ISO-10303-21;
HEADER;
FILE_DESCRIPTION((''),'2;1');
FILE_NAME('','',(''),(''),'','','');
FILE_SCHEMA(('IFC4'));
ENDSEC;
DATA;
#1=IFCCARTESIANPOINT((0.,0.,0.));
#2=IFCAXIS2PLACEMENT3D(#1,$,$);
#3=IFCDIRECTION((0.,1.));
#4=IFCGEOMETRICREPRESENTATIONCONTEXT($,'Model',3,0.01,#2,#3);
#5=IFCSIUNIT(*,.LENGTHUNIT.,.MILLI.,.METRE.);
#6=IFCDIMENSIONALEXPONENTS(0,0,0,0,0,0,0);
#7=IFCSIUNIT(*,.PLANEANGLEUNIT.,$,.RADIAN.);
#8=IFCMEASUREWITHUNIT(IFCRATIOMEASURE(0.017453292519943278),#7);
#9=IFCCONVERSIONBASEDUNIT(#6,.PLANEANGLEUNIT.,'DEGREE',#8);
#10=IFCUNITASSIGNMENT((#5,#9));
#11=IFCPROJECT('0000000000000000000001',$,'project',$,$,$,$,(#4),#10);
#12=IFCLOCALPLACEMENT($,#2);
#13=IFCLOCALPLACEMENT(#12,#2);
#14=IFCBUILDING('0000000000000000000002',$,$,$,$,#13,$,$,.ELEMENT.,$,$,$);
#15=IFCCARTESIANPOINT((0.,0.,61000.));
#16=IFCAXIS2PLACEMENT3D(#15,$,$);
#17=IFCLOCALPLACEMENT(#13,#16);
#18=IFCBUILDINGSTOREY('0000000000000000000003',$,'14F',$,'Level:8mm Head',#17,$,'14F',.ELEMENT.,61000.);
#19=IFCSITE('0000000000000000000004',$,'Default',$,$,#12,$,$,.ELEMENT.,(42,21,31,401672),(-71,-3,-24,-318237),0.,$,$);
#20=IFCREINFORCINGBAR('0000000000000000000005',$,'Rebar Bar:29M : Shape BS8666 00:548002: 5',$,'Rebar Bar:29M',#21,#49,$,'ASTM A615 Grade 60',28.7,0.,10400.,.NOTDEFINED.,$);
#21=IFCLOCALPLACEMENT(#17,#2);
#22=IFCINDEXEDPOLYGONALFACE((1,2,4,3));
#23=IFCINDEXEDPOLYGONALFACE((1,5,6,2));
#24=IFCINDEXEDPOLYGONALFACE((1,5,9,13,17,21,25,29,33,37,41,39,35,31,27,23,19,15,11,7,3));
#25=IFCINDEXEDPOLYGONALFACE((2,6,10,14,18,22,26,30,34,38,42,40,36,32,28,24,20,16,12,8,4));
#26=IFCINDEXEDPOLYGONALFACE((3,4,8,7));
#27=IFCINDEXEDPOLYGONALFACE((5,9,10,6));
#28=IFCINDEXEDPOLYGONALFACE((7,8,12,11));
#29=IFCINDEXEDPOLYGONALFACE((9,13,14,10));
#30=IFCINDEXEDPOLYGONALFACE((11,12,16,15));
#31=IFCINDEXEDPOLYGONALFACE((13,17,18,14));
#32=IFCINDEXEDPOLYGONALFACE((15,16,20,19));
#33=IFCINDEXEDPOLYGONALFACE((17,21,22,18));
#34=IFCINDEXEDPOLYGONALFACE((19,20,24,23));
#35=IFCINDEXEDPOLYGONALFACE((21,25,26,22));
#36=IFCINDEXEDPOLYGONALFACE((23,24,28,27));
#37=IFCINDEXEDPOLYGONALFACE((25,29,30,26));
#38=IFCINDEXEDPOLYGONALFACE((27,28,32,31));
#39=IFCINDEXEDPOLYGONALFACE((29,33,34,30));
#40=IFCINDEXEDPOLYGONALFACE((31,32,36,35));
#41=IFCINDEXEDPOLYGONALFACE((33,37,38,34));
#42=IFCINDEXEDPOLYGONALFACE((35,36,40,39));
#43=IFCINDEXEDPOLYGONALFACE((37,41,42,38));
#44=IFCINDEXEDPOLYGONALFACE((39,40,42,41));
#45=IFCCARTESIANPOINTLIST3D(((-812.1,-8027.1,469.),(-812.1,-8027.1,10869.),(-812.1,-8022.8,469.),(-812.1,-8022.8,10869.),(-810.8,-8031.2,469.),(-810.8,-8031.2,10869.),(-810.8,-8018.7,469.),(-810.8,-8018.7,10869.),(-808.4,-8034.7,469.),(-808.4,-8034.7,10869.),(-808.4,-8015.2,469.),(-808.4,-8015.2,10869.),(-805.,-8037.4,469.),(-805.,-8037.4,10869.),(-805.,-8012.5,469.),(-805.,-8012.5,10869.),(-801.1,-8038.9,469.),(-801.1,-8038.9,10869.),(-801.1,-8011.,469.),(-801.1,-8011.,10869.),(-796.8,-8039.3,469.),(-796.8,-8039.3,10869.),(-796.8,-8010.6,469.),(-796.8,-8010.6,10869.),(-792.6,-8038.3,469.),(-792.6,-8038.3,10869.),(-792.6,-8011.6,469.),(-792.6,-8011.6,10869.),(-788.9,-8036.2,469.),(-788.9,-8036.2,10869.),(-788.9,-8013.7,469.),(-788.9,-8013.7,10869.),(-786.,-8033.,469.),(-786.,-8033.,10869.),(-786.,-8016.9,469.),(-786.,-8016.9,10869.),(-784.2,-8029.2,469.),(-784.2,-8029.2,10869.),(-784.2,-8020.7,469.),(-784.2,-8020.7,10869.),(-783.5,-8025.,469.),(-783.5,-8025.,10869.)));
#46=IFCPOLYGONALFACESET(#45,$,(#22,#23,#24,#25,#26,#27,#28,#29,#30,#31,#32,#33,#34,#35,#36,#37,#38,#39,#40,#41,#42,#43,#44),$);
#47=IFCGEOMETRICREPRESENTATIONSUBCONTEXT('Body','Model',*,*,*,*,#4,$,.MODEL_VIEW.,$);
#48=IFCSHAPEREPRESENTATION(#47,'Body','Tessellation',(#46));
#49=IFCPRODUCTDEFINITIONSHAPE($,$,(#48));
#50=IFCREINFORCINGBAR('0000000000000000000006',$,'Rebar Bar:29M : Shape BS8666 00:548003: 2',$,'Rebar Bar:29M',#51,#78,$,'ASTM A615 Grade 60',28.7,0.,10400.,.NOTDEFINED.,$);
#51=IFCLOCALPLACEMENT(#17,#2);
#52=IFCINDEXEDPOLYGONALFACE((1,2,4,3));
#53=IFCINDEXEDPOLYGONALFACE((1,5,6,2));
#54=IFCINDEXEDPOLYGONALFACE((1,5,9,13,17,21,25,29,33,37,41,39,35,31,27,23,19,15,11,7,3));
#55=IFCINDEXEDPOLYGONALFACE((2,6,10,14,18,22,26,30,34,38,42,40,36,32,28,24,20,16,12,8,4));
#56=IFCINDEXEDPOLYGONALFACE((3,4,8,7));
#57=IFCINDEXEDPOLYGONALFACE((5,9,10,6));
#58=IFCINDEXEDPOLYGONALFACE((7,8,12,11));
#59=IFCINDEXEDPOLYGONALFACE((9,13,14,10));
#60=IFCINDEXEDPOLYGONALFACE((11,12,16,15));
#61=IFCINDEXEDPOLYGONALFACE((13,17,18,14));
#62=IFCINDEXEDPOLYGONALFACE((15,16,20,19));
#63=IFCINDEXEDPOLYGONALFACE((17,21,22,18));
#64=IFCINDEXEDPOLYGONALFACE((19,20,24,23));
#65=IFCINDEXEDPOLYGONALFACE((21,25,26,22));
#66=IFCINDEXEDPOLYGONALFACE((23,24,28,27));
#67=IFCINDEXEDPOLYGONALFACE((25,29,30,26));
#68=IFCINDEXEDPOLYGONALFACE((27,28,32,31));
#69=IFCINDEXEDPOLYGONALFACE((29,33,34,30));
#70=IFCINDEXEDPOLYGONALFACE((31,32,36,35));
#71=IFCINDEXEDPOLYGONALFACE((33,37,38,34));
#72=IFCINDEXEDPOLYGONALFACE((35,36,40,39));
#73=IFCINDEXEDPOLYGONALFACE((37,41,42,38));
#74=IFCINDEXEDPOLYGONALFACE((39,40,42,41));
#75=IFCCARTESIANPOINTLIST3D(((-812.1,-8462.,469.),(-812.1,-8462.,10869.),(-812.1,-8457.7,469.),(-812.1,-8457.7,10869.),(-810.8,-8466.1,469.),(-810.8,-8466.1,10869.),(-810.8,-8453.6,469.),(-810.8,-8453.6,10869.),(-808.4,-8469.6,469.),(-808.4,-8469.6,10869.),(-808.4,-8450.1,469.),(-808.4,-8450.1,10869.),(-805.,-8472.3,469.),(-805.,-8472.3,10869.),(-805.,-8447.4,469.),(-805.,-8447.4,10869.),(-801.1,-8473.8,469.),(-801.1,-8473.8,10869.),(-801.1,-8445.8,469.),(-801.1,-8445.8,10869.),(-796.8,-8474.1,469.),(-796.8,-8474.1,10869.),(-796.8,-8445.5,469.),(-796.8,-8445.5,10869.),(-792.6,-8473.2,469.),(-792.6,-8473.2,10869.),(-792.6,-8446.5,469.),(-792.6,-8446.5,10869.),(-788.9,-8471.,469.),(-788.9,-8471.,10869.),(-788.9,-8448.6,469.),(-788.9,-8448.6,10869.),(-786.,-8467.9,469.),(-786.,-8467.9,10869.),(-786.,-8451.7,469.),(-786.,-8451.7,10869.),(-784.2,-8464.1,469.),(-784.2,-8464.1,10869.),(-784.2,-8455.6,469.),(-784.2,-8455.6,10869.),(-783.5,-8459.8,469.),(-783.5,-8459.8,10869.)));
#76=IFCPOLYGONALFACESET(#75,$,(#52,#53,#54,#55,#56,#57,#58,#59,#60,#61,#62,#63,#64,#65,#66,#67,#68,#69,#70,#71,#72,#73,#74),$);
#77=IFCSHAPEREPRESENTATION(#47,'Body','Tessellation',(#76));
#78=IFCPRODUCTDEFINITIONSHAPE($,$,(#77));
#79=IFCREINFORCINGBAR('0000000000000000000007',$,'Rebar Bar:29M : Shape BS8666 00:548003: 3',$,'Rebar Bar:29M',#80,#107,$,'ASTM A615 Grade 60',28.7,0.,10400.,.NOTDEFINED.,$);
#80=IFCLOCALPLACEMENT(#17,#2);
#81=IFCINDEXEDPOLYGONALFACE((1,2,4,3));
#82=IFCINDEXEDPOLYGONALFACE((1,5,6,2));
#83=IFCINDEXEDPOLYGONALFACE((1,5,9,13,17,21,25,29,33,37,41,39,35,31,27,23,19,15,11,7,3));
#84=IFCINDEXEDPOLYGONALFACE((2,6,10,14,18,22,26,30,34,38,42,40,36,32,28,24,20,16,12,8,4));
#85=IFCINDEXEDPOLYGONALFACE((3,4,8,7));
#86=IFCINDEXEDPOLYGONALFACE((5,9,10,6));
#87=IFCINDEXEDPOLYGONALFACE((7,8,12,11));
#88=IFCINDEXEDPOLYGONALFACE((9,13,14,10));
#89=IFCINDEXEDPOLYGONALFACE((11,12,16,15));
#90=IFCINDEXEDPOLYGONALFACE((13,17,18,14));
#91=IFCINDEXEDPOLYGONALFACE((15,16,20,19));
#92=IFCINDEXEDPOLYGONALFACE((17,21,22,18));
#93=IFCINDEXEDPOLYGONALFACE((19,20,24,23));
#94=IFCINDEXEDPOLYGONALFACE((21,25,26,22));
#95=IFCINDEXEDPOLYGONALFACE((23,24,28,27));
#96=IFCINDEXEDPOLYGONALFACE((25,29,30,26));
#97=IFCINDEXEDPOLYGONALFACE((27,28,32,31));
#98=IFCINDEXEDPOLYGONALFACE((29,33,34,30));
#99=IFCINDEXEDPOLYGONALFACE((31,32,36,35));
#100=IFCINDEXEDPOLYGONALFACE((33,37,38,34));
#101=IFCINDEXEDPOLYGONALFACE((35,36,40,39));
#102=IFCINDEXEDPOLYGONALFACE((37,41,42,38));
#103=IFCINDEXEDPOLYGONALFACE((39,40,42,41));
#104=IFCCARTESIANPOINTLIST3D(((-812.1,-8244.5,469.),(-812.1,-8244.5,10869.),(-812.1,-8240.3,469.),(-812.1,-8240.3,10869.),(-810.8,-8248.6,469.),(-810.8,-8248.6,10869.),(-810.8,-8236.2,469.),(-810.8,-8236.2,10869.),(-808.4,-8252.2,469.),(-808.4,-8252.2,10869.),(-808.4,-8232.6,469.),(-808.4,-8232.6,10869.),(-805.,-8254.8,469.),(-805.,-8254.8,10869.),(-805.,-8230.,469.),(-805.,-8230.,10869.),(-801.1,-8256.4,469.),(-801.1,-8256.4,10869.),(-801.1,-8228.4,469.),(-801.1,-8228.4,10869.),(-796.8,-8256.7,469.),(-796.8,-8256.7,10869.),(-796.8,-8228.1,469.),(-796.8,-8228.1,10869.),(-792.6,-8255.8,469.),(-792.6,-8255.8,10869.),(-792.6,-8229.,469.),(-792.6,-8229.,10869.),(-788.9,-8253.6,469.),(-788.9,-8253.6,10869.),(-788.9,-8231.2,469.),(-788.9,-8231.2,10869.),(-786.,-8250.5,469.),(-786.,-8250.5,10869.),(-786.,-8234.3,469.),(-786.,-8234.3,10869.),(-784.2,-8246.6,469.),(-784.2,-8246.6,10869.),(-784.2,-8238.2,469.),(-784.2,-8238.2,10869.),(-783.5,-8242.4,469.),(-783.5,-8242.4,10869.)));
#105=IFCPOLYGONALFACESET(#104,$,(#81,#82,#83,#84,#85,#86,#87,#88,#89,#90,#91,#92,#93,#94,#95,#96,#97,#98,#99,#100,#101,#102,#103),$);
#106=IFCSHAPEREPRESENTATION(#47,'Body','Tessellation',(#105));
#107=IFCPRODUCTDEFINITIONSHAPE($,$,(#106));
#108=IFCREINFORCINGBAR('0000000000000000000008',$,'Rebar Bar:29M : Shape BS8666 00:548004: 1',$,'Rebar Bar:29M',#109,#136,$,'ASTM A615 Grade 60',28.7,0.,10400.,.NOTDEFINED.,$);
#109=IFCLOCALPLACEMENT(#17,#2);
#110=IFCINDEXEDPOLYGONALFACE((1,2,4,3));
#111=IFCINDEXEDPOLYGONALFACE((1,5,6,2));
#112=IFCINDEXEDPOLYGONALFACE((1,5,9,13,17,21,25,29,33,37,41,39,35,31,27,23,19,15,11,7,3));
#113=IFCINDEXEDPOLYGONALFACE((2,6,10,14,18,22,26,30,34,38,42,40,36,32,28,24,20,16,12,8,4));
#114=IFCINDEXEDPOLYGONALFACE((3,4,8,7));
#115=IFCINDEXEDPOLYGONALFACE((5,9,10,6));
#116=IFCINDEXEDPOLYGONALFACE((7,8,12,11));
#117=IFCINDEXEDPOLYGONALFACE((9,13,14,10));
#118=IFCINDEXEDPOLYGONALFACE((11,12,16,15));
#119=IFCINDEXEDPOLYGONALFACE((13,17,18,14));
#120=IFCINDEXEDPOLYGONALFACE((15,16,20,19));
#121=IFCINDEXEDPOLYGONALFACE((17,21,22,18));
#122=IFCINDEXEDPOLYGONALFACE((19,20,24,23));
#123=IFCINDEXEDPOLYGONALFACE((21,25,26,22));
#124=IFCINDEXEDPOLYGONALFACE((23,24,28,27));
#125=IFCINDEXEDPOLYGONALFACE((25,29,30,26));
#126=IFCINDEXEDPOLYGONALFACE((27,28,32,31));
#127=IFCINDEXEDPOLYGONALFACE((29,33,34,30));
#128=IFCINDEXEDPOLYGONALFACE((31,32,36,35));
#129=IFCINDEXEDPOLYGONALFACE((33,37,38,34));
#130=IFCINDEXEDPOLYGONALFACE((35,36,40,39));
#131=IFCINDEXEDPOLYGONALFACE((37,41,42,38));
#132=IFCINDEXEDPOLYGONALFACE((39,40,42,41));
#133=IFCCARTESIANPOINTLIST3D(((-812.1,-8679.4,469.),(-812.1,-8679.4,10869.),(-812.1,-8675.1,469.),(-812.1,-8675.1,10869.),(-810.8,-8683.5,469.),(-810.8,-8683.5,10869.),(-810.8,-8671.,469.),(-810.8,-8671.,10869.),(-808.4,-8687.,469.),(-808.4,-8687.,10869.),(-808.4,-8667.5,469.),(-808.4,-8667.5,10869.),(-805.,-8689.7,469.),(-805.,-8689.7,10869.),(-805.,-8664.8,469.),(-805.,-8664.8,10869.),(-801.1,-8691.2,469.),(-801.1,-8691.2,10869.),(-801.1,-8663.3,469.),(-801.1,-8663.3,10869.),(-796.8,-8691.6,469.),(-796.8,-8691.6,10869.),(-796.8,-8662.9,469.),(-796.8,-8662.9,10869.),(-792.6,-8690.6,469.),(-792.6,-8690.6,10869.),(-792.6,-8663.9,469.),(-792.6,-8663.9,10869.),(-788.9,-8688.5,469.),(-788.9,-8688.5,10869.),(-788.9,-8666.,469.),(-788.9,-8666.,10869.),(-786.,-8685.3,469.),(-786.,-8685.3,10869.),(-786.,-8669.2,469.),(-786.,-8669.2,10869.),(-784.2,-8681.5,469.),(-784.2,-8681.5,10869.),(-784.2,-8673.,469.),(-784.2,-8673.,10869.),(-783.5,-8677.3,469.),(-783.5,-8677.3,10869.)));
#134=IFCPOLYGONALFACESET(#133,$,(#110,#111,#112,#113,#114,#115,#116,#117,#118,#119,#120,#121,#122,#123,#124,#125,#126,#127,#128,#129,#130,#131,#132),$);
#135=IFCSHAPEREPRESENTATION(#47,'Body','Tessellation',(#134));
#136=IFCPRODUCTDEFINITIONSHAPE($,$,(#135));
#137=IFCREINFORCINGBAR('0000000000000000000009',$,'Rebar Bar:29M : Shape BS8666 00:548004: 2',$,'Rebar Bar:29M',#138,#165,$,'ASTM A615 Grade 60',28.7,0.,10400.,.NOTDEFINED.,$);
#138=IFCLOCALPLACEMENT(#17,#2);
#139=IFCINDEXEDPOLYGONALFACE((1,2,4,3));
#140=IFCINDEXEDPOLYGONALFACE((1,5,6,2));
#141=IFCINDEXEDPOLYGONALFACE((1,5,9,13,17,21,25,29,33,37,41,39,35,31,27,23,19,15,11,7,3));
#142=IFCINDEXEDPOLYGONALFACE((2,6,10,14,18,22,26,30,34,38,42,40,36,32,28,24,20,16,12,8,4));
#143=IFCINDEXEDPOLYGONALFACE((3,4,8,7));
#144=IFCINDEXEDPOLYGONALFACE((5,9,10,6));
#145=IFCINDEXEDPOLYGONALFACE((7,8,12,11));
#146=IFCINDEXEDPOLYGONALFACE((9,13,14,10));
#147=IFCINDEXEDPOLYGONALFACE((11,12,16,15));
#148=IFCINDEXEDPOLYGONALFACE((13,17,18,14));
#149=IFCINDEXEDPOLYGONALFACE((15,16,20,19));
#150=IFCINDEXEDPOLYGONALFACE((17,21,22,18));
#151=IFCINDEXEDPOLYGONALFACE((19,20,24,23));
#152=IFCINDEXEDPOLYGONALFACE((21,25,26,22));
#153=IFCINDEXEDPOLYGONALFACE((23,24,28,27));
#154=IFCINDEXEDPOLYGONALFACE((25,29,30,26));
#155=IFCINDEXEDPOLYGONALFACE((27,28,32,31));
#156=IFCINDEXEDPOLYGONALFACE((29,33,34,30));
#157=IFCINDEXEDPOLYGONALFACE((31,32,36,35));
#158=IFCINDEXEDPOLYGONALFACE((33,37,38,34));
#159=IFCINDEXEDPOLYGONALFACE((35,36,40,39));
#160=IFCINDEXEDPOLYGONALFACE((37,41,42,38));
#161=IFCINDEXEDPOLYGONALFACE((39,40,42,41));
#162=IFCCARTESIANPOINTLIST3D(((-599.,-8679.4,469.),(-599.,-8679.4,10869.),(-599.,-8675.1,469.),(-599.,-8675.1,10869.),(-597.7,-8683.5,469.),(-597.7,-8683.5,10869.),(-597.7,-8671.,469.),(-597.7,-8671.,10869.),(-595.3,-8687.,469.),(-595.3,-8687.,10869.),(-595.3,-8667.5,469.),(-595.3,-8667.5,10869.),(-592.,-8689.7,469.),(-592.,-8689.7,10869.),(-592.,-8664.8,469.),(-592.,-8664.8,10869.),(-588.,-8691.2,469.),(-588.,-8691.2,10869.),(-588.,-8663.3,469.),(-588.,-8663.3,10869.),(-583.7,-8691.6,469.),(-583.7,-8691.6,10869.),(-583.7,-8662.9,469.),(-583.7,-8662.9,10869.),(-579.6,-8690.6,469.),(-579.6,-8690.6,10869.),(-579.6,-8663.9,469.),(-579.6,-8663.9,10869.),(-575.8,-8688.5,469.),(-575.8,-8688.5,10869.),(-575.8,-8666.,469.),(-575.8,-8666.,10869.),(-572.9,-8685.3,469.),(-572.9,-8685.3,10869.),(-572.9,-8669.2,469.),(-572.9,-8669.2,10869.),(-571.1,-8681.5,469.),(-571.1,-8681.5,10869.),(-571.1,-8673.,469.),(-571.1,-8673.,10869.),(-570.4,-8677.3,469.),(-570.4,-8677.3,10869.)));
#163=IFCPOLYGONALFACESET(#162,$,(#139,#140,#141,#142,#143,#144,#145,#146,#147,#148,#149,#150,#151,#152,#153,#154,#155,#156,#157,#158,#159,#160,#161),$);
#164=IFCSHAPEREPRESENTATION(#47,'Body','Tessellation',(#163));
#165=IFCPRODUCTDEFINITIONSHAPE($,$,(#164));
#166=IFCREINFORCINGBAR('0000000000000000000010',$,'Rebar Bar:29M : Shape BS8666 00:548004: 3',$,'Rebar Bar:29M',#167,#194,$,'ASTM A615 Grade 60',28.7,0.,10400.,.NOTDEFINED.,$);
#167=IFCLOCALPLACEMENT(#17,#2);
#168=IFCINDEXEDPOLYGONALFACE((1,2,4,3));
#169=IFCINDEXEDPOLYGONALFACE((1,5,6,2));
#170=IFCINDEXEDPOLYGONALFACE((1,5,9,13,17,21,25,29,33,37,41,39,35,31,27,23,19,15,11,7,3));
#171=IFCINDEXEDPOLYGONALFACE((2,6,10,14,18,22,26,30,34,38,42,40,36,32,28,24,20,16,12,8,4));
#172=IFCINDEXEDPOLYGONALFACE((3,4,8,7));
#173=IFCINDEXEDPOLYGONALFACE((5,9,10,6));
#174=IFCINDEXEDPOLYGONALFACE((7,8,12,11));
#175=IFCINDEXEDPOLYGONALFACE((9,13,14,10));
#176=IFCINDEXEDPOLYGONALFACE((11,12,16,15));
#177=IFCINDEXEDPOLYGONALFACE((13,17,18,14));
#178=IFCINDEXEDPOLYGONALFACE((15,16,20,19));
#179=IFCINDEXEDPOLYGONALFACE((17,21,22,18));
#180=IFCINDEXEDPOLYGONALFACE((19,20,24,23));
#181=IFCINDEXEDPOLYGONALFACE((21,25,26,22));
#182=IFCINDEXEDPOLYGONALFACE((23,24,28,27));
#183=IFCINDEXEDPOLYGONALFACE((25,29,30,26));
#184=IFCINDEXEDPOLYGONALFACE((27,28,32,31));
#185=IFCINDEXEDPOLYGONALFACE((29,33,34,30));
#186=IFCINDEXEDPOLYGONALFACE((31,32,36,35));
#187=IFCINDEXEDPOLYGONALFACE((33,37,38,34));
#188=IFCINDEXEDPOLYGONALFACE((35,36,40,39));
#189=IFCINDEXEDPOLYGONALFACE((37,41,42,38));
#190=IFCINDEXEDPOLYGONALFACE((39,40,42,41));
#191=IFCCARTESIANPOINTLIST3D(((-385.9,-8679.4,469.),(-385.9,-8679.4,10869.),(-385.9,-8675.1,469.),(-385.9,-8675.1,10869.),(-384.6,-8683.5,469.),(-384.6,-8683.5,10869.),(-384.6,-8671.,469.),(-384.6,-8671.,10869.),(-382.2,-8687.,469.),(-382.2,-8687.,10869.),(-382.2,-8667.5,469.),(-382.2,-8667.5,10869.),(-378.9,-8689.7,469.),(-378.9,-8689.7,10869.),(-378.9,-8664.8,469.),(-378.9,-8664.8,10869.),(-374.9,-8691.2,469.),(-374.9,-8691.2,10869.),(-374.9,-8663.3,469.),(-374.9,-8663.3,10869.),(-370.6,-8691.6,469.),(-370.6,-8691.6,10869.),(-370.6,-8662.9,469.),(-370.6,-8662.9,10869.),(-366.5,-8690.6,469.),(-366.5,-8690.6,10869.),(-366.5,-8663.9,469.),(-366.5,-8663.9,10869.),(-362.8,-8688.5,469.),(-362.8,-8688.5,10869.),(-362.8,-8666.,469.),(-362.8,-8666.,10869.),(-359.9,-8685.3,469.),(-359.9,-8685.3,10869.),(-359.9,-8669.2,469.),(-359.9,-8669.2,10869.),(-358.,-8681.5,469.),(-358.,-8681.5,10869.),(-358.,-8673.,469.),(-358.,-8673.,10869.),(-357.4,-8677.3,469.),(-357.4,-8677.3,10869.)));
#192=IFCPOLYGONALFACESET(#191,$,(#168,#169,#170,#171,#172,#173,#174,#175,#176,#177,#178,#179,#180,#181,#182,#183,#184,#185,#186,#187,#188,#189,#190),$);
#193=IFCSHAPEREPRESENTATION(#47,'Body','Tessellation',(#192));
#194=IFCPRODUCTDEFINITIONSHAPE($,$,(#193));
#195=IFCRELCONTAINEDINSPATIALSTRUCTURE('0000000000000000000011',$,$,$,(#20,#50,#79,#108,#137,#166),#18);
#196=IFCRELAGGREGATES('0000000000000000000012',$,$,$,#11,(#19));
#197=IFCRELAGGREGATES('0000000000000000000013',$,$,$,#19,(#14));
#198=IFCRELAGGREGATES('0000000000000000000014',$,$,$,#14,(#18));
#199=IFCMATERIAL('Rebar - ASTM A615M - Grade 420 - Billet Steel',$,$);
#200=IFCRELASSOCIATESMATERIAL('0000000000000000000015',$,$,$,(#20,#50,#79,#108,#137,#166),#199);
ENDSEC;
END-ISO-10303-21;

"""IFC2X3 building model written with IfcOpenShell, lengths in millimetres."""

from ifc_helpers import new_model, entity, si_unit, converted_unit, direction, frame, origin, place, context, subcontext, project, spatial, material, element, save


model = new_model("IFC2X3")

# Units and contexts
model_context = context("Model", 3, precision=0.01, world=origin(), true_north=direction((0.0, 1.0)))
body_context = subcontext(model_context, "Body", "Model", "MODEL_VIEW")
ifc_project = project(units=[si_unit("LENGTHUNIT", "METRE", prefix="MILLI"), converted_unit("PLANEANGLEUNIT", "DEGREE", entity("IfcRatioMeasure", 0.017453292519943278), si_unit("PLANEANGLEUNIT", "RADIAN"), dimensions=[0, 0, 0, 0, 0, 0, 0])], contexts=[model_context])

# Site, building, storey
site_placement = place(None, origin())
site = spatial("IfcSite", under=ifc_project, at=site_placement, Name="Default", CompositionType="ELEMENT", RefLatitude=(42, 21, 31, 401672), RefLongitude=(-71, -3, -24, -318237), RefElevation=0.0)
building_placement = place(site_placement, origin())
building = spatial("IfcBuilding", under=site, at=building_placement, CompositionType="ELEMENT")
storey_placement = place(building_placement, frame((0.0, 0.0, 61000.0)))
storey = spatial("IfcBuildingStorey", under=building, at=storey_placement, Name="14F", ObjectType="Level:8mm Head", LongName="14F", CompositionType="ELEMENT", Elevation=61000.0)

# Reinforcing bars
ifc_material_1 = material(Name="Rebar - ASTM A615M - Grade 420 - Billet Steel")
reinforcing_bar_1_placement = place(storey_placement, origin())
element("IfcReinforcingBar", 1, at=reinforcing_bar_1_placement, inside=storey, material=ifc_material_1, Name="Rebar Bar:29M : Shape BS8666 00:548002: 5", SteelGrade="ASTM A615 Grade 60", ObjectType="Rebar Bar:29M", BarLength=10400.0, BarRole="NOTDEFINED", CrossSectionArea=0.0, NominalDiameter=28.7, context=body_context, shape_type="AdvancedSweptSolid", body=[
    entity("IfcSweptDiskSolid", entity("IfcCompositeCurve", [entity("IfcCompositeCurveSegment", "CONTINUOUS", True, entity("IfcPolyline", [entity("IfcCartesianPoint", [-797.9, -8025.0, 469.0]), entity("IfcCartesianPoint", [-797.9, -8025.0, 10869.0])]))], False), 14.3, None, 0.0, 1.0),
])
reinforcing_bar_2_placement = place(storey_placement, origin())
element("IfcReinforcingBar", 2, at=reinforcing_bar_2_placement, inside=storey, material=ifc_material_1, Name="Rebar Bar:29M : Shape BS8666 00:548003: 2", SteelGrade="ASTM A615 Grade 60", ObjectType="Rebar Bar:29M", BarLength=10400.0, BarRole="NOTDEFINED", CrossSectionArea=0.0, NominalDiameter=28.7, context=body_context, shape_type="AdvancedSweptSolid", body=[
    entity("IfcSweptDiskSolid", entity("IfcCompositeCurve", [entity("IfcCompositeCurveSegment", "CONTINUOUS", True, entity("IfcPolyline", [entity("IfcCartesianPoint", [-797.9, -8459.8, 469.0]), entity("IfcCartesianPoint", [-797.9, -8459.8, 10869.0])]))], False), 14.3, None, 0.0, 1.0),
])
reinforcing_bar_3_placement = place(storey_placement, origin())
element("IfcReinforcingBar", 3, at=reinforcing_bar_3_placement, inside=storey, material=ifc_material_1, Name="Rebar Bar:29M : Shape BS8666 00:548003: 3", SteelGrade="ASTM A615 Grade 60", ObjectType="Rebar Bar:29M", BarLength=10400.0, BarRole="NOTDEFINED", CrossSectionArea=0.0, NominalDiameter=28.7, context=body_context, shape_type="AdvancedSweptSolid", body=[
    entity("IfcSweptDiskSolid", entity("IfcCompositeCurve", [entity("IfcCompositeCurveSegment", "CONTINUOUS", True, entity("IfcPolyline", [entity("IfcCartesianPoint", [-797.9, -8242.4, 469.0]), entity("IfcCartesianPoint", [-797.9, -8242.4, 10869.0])]))], False), 14.3, None, 0.0, 1.0),
])
reinforcing_bar_4_placement = place(storey_placement, origin())
element("IfcReinforcingBar", 4, at=reinforcing_bar_4_placement, inside=storey, material=ifc_material_1, Name="Rebar Bar:29M : Shape BS8666 00:548004: 1", SteelGrade="ASTM A615 Grade 60", ObjectType="Rebar Bar:29M", BarLength=10400.0, BarRole="NOTDEFINED", CrossSectionArea=0.0, NominalDiameter=28.7, context=body_context, shape_type="AdvancedSweptSolid", body=[
    entity("IfcSweptDiskSolid", entity("IfcCompositeCurve", [entity("IfcCompositeCurveSegment", "CONTINUOUS", True, entity("IfcPolyline", [entity("IfcCartesianPoint", [-797.9, -8677.3, 469.0]), entity("IfcCartesianPoint", [-797.9, -8677.3, 10869.0])]))], False), 14.3, None, 0.0, 1.0),
])
reinforcing_bar_5_placement = place(storey_placement, origin())
element("IfcReinforcingBar", 5, at=reinforcing_bar_5_placement, inside=storey, material=ifc_material_1, Name="Rebar Bar:29M : Shape BS8666 00:548004: 2", SteelGrade="ASTM A615 Grade 60", ObjectType="Rebar Bar:29M", BarLength=10400.0, BarRole="NOTDEFINED", CrossSectionArea=0.0, NominalDiameter=28.7, context=body_context, shape_type="AdvancedSweptSolid", body=[
    entity("IfcSweptDiskSolid", entity("IfcCompositeCurve", [entity("IfcCompositeCurveSegment", "CONTINUOUS", True, entity("IfcPolyline", [entity("IfcCartesianPoint", [-584.8, -8677.3, 469.0]), entity("IfcCartesianPoint", [-584.8, -8677.3, 10869.0])]))], False), 14.3, None, 0.0, 1.0),
])
reinforcing_bar_6_placement = place(storey_placement, origin())
element("IfcReinforcingBar", 6, at=reinforcing_bar_6_placement, inside=storey, material=ifc_material_1, Name="Rebar Bar:29M : Shape BS8666 00:548004: 3", SteelGrade="ASTM A615 Grade 60", ObjectType="Rebar Bar:29M", BarLength=10400.0, BarRole="NOTDEFINED", CrossSectionArea=0.0, NominalDiameter=28.7, context=body_context, shape_type="AdvancedSweptSolid", body=[
    entity("IfcSweptDiskSolid", entity("IfcCompositeCurve", [entity("IfcCompositeCurveSegment", "CONTINUOUS", True, entity("IfcPolyline", [entity("IfcCartesianPoint", [-371.7, -8677.3, 469.0]), entity("IfcCartesianPoint", [-371.7, -8677.3, 10869.0])]))], False), 14.3, None, 0.0, 1.0),
])

save(model, "model.ifc")
